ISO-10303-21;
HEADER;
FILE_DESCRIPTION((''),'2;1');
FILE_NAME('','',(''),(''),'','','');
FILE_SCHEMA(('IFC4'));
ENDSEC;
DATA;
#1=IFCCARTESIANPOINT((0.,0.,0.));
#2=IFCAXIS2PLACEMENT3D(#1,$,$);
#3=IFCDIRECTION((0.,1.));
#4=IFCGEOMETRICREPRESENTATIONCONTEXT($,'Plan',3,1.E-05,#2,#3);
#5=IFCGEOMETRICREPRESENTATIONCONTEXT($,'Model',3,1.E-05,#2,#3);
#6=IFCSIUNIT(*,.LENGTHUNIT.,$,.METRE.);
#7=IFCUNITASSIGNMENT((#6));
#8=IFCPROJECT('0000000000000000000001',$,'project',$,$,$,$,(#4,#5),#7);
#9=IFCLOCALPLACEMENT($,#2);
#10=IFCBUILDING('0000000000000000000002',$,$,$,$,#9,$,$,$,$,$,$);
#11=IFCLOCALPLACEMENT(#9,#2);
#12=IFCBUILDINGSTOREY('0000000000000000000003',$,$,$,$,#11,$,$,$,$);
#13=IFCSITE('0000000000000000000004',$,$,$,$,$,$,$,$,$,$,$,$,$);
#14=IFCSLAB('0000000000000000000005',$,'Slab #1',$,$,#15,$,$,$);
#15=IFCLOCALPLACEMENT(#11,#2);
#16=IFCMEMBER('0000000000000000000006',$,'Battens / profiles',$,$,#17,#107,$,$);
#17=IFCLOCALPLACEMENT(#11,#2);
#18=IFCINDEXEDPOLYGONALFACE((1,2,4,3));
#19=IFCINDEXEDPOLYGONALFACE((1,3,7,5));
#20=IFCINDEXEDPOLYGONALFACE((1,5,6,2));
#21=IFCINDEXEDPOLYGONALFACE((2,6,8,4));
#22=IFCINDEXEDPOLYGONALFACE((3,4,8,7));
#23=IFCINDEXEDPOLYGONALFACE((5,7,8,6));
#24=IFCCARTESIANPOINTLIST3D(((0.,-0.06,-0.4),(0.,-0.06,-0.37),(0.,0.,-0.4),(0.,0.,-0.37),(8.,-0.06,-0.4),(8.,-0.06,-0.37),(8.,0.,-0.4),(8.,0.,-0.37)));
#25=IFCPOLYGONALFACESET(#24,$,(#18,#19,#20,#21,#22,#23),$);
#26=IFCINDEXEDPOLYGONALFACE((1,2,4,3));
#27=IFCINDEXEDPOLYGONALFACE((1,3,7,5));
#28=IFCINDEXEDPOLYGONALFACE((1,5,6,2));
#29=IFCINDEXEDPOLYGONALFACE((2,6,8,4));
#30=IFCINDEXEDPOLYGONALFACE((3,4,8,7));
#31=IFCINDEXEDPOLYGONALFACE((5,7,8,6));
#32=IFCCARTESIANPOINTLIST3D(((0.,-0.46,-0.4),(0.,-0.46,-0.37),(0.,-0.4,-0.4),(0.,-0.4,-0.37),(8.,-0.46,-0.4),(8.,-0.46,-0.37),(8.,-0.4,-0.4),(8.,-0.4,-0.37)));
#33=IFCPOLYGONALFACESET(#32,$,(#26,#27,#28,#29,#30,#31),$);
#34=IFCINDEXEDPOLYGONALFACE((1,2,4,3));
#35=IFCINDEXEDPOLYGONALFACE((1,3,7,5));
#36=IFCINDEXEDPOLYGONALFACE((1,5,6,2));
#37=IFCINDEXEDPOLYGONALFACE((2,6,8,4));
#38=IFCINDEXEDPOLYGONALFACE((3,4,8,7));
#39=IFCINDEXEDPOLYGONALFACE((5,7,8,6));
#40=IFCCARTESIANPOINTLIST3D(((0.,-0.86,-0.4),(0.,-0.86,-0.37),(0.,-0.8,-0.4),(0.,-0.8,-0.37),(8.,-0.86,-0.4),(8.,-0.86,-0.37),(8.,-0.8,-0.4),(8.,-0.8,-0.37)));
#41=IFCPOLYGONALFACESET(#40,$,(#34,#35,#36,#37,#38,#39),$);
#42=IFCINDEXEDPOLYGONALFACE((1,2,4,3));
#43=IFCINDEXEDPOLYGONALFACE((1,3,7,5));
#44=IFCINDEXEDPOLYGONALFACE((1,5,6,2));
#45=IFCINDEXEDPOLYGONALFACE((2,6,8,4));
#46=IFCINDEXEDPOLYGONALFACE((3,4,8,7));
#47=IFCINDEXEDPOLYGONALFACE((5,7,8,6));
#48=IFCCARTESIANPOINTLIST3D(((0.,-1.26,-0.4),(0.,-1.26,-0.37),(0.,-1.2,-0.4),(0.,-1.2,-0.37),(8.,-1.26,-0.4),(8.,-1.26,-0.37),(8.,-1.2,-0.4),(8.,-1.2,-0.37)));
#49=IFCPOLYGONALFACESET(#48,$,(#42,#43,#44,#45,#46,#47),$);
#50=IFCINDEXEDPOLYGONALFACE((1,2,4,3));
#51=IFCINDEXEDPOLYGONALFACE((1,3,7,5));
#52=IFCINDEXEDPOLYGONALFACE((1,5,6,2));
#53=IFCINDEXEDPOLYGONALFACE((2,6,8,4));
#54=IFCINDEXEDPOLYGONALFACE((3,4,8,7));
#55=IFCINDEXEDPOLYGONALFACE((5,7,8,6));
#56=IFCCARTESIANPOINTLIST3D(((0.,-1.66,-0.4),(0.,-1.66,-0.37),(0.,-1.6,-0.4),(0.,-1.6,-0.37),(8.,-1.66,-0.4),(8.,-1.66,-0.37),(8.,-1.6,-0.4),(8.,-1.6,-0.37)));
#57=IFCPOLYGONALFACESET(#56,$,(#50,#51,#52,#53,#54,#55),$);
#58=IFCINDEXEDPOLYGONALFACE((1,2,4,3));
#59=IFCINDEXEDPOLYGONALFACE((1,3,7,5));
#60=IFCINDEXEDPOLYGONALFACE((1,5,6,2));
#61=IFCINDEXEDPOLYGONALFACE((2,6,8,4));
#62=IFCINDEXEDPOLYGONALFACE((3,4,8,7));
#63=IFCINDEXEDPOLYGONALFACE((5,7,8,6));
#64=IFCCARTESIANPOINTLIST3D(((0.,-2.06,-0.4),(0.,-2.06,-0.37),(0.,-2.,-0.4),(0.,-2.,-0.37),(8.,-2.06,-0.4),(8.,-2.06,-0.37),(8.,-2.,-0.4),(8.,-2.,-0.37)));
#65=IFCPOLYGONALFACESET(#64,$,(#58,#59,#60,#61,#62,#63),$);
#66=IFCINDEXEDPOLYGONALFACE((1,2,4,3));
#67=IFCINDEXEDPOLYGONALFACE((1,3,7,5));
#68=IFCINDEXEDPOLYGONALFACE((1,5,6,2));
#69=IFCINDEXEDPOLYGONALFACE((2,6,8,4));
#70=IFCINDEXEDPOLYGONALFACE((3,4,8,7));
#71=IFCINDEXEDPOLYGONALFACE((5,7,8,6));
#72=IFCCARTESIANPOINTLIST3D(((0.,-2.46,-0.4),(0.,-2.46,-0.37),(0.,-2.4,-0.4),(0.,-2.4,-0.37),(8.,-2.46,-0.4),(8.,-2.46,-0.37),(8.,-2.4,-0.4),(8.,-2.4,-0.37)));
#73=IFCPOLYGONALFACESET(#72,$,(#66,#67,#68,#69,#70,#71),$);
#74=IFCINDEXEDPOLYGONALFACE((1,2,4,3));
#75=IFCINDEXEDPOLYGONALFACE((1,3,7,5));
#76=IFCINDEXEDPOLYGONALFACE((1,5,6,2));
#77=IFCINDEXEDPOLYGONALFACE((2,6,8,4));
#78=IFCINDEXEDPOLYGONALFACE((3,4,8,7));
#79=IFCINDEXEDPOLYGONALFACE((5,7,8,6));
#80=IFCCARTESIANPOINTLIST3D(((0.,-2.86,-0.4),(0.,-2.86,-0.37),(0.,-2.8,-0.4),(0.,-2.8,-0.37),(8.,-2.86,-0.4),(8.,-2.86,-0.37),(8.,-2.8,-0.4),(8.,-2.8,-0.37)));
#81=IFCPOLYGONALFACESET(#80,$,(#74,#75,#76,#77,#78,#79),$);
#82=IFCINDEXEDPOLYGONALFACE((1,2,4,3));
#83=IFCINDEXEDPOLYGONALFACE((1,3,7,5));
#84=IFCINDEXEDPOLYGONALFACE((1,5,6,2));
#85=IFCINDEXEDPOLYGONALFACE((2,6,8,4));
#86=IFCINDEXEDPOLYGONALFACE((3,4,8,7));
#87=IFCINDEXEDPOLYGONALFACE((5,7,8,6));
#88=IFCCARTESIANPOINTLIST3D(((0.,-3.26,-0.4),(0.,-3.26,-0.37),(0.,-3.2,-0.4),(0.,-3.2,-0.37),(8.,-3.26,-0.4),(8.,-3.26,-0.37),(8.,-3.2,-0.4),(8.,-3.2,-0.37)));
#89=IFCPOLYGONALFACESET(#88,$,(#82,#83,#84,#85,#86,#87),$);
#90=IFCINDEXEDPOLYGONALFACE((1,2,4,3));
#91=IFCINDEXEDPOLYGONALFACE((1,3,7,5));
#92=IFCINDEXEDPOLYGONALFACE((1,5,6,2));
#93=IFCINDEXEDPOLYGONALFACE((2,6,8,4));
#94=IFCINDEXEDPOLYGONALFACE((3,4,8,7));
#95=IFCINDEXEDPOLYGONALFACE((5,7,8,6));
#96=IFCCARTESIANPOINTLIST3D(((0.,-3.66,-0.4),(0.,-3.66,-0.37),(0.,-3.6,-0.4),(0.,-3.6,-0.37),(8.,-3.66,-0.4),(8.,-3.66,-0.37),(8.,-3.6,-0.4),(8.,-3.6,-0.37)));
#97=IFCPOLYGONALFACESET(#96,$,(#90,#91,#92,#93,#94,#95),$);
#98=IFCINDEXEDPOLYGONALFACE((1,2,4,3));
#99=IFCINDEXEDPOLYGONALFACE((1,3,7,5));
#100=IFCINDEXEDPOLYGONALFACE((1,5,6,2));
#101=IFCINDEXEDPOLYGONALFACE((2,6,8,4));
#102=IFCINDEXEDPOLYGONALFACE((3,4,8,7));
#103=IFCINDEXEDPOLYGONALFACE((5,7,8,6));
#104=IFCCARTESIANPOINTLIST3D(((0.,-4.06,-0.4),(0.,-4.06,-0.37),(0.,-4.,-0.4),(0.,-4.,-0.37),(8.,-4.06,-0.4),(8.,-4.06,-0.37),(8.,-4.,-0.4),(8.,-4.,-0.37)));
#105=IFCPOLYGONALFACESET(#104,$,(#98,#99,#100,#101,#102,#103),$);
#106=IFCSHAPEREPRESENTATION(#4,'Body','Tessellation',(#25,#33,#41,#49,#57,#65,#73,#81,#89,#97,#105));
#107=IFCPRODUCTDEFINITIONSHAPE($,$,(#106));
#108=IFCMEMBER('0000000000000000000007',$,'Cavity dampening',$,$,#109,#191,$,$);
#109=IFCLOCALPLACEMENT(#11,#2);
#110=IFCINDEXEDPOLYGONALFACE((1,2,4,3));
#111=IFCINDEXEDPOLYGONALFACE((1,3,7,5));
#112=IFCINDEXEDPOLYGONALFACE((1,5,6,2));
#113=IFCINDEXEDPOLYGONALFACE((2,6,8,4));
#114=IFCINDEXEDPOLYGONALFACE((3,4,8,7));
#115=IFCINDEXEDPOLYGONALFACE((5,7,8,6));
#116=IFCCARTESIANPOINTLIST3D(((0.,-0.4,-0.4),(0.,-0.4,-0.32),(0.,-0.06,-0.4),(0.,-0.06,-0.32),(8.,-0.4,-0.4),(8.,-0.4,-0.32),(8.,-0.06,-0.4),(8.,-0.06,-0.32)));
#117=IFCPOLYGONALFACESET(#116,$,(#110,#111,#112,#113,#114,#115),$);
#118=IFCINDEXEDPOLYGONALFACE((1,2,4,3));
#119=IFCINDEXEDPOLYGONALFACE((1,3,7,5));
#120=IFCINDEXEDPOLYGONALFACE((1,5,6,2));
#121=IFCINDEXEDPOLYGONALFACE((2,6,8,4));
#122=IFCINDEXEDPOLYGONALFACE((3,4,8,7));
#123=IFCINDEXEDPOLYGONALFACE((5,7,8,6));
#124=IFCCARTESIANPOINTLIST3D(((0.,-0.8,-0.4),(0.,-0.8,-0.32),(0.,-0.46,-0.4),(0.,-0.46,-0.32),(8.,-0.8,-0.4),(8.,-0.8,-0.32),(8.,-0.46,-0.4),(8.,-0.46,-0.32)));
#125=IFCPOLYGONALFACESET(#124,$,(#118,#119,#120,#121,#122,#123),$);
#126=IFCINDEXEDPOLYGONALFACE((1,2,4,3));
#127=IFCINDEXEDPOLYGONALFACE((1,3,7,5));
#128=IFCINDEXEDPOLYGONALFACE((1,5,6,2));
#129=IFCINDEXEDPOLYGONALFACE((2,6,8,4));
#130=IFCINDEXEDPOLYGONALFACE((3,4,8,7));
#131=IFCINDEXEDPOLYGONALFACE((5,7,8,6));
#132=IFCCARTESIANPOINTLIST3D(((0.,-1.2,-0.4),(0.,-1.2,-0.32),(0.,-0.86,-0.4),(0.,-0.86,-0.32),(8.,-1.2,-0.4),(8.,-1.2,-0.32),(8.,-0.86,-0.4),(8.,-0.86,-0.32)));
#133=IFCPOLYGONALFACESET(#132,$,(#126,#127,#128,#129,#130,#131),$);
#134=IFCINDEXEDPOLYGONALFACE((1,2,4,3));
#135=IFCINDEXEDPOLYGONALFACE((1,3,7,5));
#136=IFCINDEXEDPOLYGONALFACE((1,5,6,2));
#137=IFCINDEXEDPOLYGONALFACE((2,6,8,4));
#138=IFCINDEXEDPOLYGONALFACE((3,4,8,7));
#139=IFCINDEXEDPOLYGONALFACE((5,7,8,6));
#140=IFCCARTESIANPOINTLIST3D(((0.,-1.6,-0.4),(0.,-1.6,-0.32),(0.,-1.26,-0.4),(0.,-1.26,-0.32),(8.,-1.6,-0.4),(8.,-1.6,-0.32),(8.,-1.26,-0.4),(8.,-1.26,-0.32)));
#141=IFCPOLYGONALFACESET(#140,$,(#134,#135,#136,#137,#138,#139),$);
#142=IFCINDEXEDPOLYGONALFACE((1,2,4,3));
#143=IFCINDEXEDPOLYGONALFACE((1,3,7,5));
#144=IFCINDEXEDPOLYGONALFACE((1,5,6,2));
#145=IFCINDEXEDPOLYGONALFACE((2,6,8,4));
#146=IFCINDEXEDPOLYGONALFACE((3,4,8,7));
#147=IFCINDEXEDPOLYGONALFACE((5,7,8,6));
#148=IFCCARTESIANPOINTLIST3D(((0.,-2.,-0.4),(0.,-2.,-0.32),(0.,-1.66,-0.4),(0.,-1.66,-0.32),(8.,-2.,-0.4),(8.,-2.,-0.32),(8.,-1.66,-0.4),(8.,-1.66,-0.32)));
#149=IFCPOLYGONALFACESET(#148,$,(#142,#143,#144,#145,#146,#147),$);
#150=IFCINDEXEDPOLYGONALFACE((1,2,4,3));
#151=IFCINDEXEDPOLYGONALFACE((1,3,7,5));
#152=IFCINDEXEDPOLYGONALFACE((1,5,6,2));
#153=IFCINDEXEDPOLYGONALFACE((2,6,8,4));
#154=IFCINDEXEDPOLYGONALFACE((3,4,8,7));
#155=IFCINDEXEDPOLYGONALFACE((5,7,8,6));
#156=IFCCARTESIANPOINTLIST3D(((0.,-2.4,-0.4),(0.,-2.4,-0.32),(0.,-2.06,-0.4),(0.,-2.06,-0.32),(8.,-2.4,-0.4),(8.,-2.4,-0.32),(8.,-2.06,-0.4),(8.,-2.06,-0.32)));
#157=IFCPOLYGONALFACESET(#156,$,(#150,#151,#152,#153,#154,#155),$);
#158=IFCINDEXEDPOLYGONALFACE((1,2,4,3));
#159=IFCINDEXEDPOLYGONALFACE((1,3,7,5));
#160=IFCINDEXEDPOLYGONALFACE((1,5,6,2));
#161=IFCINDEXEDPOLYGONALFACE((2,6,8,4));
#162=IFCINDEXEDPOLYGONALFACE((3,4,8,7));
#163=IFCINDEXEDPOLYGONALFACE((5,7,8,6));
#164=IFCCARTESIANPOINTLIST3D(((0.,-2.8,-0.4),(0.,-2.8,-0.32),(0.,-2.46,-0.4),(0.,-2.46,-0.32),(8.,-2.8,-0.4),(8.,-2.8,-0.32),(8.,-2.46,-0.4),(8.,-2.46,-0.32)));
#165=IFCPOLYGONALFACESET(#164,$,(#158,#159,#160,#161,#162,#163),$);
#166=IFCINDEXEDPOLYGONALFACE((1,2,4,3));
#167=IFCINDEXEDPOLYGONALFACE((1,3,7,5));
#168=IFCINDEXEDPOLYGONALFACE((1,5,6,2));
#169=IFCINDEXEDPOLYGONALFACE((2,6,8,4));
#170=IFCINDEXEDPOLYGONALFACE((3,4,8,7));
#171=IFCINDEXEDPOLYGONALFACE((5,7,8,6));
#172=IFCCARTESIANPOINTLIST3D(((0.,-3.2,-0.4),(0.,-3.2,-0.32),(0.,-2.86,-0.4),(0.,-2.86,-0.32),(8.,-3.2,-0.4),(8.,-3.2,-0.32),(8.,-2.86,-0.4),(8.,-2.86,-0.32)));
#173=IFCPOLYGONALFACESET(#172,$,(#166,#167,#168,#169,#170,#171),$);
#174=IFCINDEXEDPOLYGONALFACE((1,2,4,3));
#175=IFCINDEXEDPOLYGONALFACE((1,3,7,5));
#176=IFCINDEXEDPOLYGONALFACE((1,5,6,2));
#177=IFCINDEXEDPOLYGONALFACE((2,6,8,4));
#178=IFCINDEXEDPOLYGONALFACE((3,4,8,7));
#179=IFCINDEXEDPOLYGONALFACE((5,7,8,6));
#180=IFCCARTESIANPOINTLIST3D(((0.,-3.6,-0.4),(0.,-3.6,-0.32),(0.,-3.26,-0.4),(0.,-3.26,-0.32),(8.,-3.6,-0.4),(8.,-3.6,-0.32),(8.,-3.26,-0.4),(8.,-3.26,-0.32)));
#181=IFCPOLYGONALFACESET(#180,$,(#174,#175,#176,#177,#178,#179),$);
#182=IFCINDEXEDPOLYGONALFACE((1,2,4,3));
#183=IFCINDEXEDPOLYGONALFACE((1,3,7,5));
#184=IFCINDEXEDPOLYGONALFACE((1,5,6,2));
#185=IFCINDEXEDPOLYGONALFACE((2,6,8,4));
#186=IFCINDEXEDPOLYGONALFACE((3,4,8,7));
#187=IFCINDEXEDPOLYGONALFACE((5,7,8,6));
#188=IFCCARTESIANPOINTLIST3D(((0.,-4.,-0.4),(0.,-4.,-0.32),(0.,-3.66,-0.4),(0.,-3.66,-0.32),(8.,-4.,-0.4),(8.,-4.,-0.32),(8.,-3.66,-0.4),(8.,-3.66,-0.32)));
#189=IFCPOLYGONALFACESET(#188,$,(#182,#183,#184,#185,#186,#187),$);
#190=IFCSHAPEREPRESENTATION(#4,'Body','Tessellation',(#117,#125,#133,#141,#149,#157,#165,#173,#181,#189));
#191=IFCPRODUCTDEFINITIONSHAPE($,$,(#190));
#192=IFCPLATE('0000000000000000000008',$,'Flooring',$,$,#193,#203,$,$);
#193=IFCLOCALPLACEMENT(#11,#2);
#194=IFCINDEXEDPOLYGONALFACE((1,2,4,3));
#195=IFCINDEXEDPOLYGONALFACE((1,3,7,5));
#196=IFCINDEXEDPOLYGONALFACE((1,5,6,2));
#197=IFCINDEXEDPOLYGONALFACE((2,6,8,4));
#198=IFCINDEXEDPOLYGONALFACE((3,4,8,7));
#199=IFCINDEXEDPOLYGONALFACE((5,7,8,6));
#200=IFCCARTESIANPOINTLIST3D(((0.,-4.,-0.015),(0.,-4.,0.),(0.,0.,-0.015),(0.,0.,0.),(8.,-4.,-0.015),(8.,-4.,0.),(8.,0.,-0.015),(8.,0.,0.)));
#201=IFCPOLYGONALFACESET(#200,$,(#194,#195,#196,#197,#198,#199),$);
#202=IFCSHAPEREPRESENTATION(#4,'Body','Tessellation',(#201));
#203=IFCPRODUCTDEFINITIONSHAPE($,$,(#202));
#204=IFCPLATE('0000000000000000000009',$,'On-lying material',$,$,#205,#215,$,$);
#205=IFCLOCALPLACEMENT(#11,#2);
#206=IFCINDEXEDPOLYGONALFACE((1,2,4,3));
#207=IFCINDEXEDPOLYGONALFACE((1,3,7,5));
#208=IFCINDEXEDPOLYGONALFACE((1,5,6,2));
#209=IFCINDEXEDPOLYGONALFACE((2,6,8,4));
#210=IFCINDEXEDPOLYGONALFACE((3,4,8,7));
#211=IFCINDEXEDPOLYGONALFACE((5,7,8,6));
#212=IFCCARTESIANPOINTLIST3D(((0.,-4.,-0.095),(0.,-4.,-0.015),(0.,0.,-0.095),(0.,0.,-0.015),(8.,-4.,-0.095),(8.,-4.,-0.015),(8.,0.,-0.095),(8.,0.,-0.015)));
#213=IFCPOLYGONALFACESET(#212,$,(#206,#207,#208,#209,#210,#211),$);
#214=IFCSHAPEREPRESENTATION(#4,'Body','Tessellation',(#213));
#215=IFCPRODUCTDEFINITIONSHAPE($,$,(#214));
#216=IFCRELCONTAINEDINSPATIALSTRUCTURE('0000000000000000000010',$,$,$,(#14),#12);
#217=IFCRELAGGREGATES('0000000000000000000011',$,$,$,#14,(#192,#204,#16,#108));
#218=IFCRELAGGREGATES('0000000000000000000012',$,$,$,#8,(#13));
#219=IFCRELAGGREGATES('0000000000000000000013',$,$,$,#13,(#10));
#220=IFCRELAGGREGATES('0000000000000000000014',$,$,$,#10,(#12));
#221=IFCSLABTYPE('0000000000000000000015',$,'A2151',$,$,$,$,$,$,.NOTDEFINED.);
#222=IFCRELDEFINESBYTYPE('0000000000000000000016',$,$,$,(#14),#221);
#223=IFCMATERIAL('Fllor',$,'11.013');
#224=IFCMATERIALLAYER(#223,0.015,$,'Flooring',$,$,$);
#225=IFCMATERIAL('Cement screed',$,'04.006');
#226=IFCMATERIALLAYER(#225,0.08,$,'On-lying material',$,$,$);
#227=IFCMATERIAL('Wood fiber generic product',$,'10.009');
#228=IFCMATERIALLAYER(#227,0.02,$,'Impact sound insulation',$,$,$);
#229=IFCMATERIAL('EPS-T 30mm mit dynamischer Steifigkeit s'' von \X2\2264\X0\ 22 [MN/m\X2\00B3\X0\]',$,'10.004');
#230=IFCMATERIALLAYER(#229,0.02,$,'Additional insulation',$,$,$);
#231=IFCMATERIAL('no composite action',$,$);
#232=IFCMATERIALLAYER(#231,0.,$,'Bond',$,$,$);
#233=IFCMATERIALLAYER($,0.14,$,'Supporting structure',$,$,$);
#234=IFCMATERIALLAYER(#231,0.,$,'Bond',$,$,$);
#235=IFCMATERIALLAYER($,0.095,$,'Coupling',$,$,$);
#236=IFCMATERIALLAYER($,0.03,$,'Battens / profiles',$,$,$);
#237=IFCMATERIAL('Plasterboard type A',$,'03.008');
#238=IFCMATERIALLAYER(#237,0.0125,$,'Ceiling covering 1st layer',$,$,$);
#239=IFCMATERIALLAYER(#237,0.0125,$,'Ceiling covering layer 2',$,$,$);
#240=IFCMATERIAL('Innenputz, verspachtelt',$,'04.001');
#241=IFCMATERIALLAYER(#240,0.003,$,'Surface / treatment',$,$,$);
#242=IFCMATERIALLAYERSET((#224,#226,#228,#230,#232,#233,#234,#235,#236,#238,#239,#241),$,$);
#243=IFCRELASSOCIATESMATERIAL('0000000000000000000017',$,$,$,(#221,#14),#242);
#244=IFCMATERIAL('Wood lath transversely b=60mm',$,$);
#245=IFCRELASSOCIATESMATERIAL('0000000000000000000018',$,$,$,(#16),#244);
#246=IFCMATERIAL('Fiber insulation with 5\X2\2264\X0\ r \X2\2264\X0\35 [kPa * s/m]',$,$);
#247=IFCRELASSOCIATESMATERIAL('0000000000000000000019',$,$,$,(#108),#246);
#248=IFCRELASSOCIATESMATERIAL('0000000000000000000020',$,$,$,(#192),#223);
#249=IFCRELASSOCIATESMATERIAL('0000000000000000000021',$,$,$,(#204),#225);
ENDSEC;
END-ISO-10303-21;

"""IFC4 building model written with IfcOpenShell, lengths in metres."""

from ifc_helpers import new_model, si_unit, direction, frame, frame_2d, origin, origin_with_axes, place, context, project, spatial, rectangle, extrude, material, layer, layer_set, type_object, element, aggregate, save


model = new_model("IFC4")

# Units and contexts
plan_context = context("Plan", 3, precision=1e-05, world=origin(), true_north=direction((0.0, 1.0)))
model_context = context("Model", 3, precision=1e-05, world=origin(), true_north=direction((0.0, 1.0)))
ifc_project = project(units=[si_unit("LENGTHUNIT", "METRE")], contexts=[plan_context, model_context])

# Site, building, storey
site = spatial("IfcSite", under=ifc_project)
building_placement = place(None, origin())
building = spatial("IfcBuilding", under=site, at=building_placement)
storey_placement = place(building_placement, origin())
storey = spatial("IfcBuildingStorey", under=building, at=storey_placement)

# Slab, members, plates
ifc_material_1 = material(Name="Fllor", Category="11.013")
ifc_layer_1 = layer(ifc_material_1, 0.015, Name="Flooring")
ifc_material_2 = material(Name="Cement screed", Category="04.006")
ifc_layer_2 = layer(ifc_material_2, 0.08, Name="On-lying material")
ifc_material_3 = material(Name="Wood fiber generic product", Category="10.009")
ifc_layer_3 = layer(ifc_material_3, 0.02, Name="Impact sound insulation")
ifc_material_4 = material(Name="EPS-T 30mm mit dynamischer Steifigkeit s' von ≤ 22 [MN/m³]", Category="10.004")
ifc_layer_4 = layer(ifc_material_4, 0.02, Name="Additional insulation")
ifc_material_5 = material(Name="no composite action")
ifc_layer_5 = layer(ifc_material_5, 0.0, Name="Bond")
ifc_layer_6 = layer(None, 0.14, Name="Supporting structure")
ifc_layer_7 = layer(ifc_material_5, 0.0, Name="Bond")
ifc_layer_8 = layer(None, 0.095, Name="Coupling")
ifc_layer_9 = layer(None, 0.03, Name="Battens / profiles")
ifc_material_6 = material(Name="Plasterboard type A", Category="03.008")
ifc_layer_10 = layer(ifc_material_6, 0.0125, Name="Ceiling covering 1st layer")
ifc_layer_11 = layer(ifc_material_6, 0.0125, Name="Ceiling covering layer 2")
ifc_material_7 = material(Name="Innenputz, verspachtelt", Category="04.001")
ifc_layer_12 = layer(ifc_material_7, 0.003, Name="Surface / treatment")
ifc_layer_set = layer_set([ifc_layer_1, ifc_layer_2, ifc_layer_3, ifc_layer_4, ifc_layer_5, ifc_layer_6, ifc_layer_7, ifc_layer_8, ifc_layer_9, ifc_layer_10, ifc_layer_11, ifc_layer_12])
slab_type = type_object("IfcSlabType", Name="A2151", PredefinedType="NOTDEFINED", material=ifc_layer_set)
slab_placement = place(None, frame((0.0, 0.0, 0.0), z_axis=(0.0, 0.0, -1.0), x_axis=(1.0, 0.0, 0.0)))
slab = element("IfcSlab", 1, at=slab_placement, inside=storey, type_object=slab_type, material=ifc_layer_set, Name="Slab #1")
ifc_material_8 = material(Name="Wood lath transversely b=60mm")
member_1_placement = place(slab_placement, origin())
member_1 = element("IfcMember", 2, at=member_1_placement, material=ifc_material_8, Name="Battens / profiles", context=plan_context, shape_type="SweptSolid", body=[
    extrude(rectangle(XDim=0.06, YDim=0.03, at=frame_2d((0.03, 0.015), x_axis=(1.0, 0.0))), frame((0.0, 0.0, 0.37), z_axis=(1.0, 0.0, 0.0), x_axis=(0.0, 1.0, 0.0)), (0.0, 0.0, 1.0), 8.0),
    extrude(rectangle(XDim=0.06, YDim=0.03, at=frame_2d((0.03, 0.015), x_axis=(1.0, 0.0))), frame((0.0, 0.4, 0.37), z_axis=(1.0, 0.0, 0.0), x_axis=(0.0, 1.0, 0.0)), (0.0, 0.0, 1.0), 8.0),
    extrude(rectangle(XDim=0.06, YDim=0.03, at=frame_2d((0.03, 0.015), x_axis=(1.0, 0.0))), frame((0.0, 0.8, 0.37), z_axis=(1.0, 0.0, 0.0), x_axis=(0.0, 1.0, 0.0)), (0.0, 0.0, 1.0), 8.0),
    extrude(rectangle(XDim=0.06, YDim=0.03, at=frame_2d((0.03, 0.015), x_axis=(1.0, 0.0))), frame((0.0, 1.2, 0.37), z_axis=(1.0, 0.0, 0.0), x_axis=(0.0, 1.0, 0.0)), (0.0, 0.0, 1.0), 8.0),
    extrude(rectangle(XDim=0.06, YDim=0.03, at=frame_2d((0.03, 0.015), x_axis=(1.0, 0.0))), frame((0.0, 1.6, 0.37), z_axis=(1.0, 0.0, 0.0), x_axis=(0.0, 1.0, 0.0)), (0.0, 0.0, 1.0), 8.0),
    extrude(rectangle(XDim=0.06, YDim=0.03, at=frame_2d((0.03, 0.015), x_axis=(1.0, 0.0))), frame((0.0, 2.0, 0.37), z_axis=(1.0, 0.0, 0.0), x_axis=(0.0, 1.0, 0.0)), (0.0, 0.0, 1.0), 8.0),
    extrude(rectangle(XDim=0.06, YDim=0.03, at=frame_2d((0.03, 0.015), x_axis=(1.0, 0.0))), frame((0.0, 2.4, 0.37), z_axis=(1.0, 0.0, 0.0), x_axis=(0.0, 1.0, 0.0)), (0.0, 0.0, 1.0), 8.0),
    extrude(rectangle(XDim=0.06, YDim=0.03, at=frame_2d((0.03, 0.015), x_axis=(1.0, 0.0))), frame((0.0, 2.8, 0.37), z_axis=(1.0, 0.0, 0.0), x_axis=(0.0, 1.0, 0.0)), (0.0, 0.0, 1.0), 8.0),
    extrude(rectangle(XDim=0.06, YDim=0.03, at=frame_2d((0.03, 0.015), x_axis=(1.0, 0.0))), frame((0.0, 3.2, 0.37), z_axis=(1.0, 0.0, 0.0), x_axis=(0.0, 1.0, 0.0)), (0.0, 0.0, 1.0), 8.0),
    extrude(rectangle(XDim=0.06, YDim=0.03, at=frame_2d((0.03, 0.015), x_axis=(1.0, 0.0))), frame((0.0, 3.6, 0.37), z_axis=(1.0, 0.0, 0.0), x_axis=(0.0, 1.0, 0.0)), (0.0, 0.0, 1.0), 8.0),
    extrude(rectangle(XDim=0.06, YDim=0.03, at=frame_2d((0.03, 0.015), x_axis=(1.0, 0.0))), frame((0.0, 4.0, 0.37), z_axis=(1.0, 0.0, 0.0), x_axis=(0.0, 1.0, 0.0)), (0.0, 0.0, 1.0), 8.0),
])
ifc_material_9 = material(Name="Fiber insulation with 5≤ r ≤35 [kPa * s/m]")
member_2_placement = place(slab_placement, origin())
member_2 = element("IfcMember", 3, at=member_2_placement, material=ifc_material_9, Name="Cavity dampening", context=plan_context, shape_type="SweptSolid", body=[
    extrude(rectangle(XDim=0.34, YDim=0.08, at=frame_2d((0.17, 0.04), x_axis=(1.0, 0.0))), frame((0.0, 0.06, 0.32), z_axis=(1.0, 0.0, 0.0), x_axis=(0.0, 1.0, 0.0)), (0.0, 0.0, 1.0), 8.0),
    extrude(rectangle(XDim=0.34, YDim=0.08, at=frame_2d((0.17, 0.04), x_axis=(1.0, 0.0))), frame((0.0, 0.46, 0.32), z_axis=(1.0, 0.0, 0.0), x_axis=(0.0, 1.0, 0.0)), (0.0, 0.0, 1.0), 8.0),
    extrude(rectangle(XDim=0.34, YDim=0.08, at=frame_2d((0.17, 0.04), x_axis=(1.0, 0.0))), frame((0.0, 0.86, 0.32), z_axis=(1.0, 0.0, 0.0), x_axis=(0.0, 1.0, 0.0)), (0.0, 0.0, 1.0), 8.0),
    extrude(rectangle(XDim=0.34, YDim=0.08, at=frame_2d((0.17, 0.04), x_axis=(1.0, 0.0))), frame((0.0, 1.26, 0.32), z_axis=(1.0, 0.0, 0.0), x_axis=(0.0, 1.0, 0.0)), (0.0, 0.0, 1.0), 8.0),
    extrude(rectangle(XDim=0.34, YDim=0.08, at=frame_2d((0.17, 0.04), x_axis=(1.0, 0.0))), frame((0.0, 1.66, 0.32), z_axis=(1.0, 0.0, 0.0), x_axis=(0.0, 1.0, 0.0)), (0.0, 0.0, 1.0), 8.0),
    extrude(rectangle(XDim=0.34, YDim=0.08, at=frame_2d((0.17, 0.04), x_axis=(1.0, 0.0))), frame((0.0, 2.06, 0.32), z_axis=(1.0, 0.0, 0.0), x_axis=(0.0, 1.0, 0.0)), (0.0, 0.0, 1.0), 8.0),
    extrude(rectangle(XDim=0.34, YDim=0.08, at=frame_2d((0.17, 0.04), x_axis=(1.0, 0.0))), frame((0.0, 2.46, 0.32), z_axis=(1.0, 0.0, 0.0), x_axis=(0.0, 1.0, 0.0)), (0.0, 0.0, 1.0), 8.0),
    extrude(rectangle(XDim=0.34, YDim=0.08, at=frame_2d((0.17, 0.04), x_axis=(1.0, 0.0))), frame((0.0, 2.86, 0.32), z_axis=(1.0, 0.0, 0.0), x_axis=(0.0, 1.0, 0.0)), (0.0, 0.0, 1.0), 8.0),
    extrude(rectangle(XDim=0.34, YDim=0.08, at=frame_2d((0.17, 0.04), x_axis=(1.0, 0.0))), frame((0.0, 3.26, 0.32), z_axis=(1.0, 0.0, 0.0), x_axis=(0.0, 1.0, 0.0)), (0.0, 0.0, 1.0), 8.0),
    extrude(rectangle(XDim=0.34, YDim=0.08, at=frame_2d((0.17, 0.04), x_axis=(1.0, 0.0))), frame((0.0, 3.66, 0.32), z_axis=(1.0, 0.0, 0.0), x_axis=(0.0, 1.0, 0.0)), (0.0, 0.0, 1.0), 8.0),
])
plate_1_placement = place(slab_placement, origin())
plate_1 = element("IfcPlate", 4, at=plate_1_placement, material=ifc_material_1, Name="Flooring", context=plan_context, shape_type="SweptSolid", body=[
    extrude(rectangle(XDim=8.0, YDim=4.0, at=frame_2d((4.0, 2.0), x_axis=(1.0, 0.0))), origin_with_axes(), (0.0, 0.0, 1.0), 0.015),
])
plate_2_placement = place(slab_placement, origin())
plate_2 = element("IfcPlate", 5, at=plate_2_placement, material=ifc_material_2, Name="On-lying material", context=plan_context, shape_type="SweptSolid", body=[
    extrude(rectangle(XDim=8.0, YDim=4.0, at=frame_2d((4.0, 2.0), x_axis=(1.0, 0.0))), frame((0.0, 0.0, 0.015), z_axis=(0.0, 0.0, 1.0), x_axis=(1.0, 0.0, 0.0)), (0.0, 0.0, 1.0), 0.08),
])
aggregate(slab, [plate_1, plate_2, member_1, member_2])

save(model, "model.ifc")
